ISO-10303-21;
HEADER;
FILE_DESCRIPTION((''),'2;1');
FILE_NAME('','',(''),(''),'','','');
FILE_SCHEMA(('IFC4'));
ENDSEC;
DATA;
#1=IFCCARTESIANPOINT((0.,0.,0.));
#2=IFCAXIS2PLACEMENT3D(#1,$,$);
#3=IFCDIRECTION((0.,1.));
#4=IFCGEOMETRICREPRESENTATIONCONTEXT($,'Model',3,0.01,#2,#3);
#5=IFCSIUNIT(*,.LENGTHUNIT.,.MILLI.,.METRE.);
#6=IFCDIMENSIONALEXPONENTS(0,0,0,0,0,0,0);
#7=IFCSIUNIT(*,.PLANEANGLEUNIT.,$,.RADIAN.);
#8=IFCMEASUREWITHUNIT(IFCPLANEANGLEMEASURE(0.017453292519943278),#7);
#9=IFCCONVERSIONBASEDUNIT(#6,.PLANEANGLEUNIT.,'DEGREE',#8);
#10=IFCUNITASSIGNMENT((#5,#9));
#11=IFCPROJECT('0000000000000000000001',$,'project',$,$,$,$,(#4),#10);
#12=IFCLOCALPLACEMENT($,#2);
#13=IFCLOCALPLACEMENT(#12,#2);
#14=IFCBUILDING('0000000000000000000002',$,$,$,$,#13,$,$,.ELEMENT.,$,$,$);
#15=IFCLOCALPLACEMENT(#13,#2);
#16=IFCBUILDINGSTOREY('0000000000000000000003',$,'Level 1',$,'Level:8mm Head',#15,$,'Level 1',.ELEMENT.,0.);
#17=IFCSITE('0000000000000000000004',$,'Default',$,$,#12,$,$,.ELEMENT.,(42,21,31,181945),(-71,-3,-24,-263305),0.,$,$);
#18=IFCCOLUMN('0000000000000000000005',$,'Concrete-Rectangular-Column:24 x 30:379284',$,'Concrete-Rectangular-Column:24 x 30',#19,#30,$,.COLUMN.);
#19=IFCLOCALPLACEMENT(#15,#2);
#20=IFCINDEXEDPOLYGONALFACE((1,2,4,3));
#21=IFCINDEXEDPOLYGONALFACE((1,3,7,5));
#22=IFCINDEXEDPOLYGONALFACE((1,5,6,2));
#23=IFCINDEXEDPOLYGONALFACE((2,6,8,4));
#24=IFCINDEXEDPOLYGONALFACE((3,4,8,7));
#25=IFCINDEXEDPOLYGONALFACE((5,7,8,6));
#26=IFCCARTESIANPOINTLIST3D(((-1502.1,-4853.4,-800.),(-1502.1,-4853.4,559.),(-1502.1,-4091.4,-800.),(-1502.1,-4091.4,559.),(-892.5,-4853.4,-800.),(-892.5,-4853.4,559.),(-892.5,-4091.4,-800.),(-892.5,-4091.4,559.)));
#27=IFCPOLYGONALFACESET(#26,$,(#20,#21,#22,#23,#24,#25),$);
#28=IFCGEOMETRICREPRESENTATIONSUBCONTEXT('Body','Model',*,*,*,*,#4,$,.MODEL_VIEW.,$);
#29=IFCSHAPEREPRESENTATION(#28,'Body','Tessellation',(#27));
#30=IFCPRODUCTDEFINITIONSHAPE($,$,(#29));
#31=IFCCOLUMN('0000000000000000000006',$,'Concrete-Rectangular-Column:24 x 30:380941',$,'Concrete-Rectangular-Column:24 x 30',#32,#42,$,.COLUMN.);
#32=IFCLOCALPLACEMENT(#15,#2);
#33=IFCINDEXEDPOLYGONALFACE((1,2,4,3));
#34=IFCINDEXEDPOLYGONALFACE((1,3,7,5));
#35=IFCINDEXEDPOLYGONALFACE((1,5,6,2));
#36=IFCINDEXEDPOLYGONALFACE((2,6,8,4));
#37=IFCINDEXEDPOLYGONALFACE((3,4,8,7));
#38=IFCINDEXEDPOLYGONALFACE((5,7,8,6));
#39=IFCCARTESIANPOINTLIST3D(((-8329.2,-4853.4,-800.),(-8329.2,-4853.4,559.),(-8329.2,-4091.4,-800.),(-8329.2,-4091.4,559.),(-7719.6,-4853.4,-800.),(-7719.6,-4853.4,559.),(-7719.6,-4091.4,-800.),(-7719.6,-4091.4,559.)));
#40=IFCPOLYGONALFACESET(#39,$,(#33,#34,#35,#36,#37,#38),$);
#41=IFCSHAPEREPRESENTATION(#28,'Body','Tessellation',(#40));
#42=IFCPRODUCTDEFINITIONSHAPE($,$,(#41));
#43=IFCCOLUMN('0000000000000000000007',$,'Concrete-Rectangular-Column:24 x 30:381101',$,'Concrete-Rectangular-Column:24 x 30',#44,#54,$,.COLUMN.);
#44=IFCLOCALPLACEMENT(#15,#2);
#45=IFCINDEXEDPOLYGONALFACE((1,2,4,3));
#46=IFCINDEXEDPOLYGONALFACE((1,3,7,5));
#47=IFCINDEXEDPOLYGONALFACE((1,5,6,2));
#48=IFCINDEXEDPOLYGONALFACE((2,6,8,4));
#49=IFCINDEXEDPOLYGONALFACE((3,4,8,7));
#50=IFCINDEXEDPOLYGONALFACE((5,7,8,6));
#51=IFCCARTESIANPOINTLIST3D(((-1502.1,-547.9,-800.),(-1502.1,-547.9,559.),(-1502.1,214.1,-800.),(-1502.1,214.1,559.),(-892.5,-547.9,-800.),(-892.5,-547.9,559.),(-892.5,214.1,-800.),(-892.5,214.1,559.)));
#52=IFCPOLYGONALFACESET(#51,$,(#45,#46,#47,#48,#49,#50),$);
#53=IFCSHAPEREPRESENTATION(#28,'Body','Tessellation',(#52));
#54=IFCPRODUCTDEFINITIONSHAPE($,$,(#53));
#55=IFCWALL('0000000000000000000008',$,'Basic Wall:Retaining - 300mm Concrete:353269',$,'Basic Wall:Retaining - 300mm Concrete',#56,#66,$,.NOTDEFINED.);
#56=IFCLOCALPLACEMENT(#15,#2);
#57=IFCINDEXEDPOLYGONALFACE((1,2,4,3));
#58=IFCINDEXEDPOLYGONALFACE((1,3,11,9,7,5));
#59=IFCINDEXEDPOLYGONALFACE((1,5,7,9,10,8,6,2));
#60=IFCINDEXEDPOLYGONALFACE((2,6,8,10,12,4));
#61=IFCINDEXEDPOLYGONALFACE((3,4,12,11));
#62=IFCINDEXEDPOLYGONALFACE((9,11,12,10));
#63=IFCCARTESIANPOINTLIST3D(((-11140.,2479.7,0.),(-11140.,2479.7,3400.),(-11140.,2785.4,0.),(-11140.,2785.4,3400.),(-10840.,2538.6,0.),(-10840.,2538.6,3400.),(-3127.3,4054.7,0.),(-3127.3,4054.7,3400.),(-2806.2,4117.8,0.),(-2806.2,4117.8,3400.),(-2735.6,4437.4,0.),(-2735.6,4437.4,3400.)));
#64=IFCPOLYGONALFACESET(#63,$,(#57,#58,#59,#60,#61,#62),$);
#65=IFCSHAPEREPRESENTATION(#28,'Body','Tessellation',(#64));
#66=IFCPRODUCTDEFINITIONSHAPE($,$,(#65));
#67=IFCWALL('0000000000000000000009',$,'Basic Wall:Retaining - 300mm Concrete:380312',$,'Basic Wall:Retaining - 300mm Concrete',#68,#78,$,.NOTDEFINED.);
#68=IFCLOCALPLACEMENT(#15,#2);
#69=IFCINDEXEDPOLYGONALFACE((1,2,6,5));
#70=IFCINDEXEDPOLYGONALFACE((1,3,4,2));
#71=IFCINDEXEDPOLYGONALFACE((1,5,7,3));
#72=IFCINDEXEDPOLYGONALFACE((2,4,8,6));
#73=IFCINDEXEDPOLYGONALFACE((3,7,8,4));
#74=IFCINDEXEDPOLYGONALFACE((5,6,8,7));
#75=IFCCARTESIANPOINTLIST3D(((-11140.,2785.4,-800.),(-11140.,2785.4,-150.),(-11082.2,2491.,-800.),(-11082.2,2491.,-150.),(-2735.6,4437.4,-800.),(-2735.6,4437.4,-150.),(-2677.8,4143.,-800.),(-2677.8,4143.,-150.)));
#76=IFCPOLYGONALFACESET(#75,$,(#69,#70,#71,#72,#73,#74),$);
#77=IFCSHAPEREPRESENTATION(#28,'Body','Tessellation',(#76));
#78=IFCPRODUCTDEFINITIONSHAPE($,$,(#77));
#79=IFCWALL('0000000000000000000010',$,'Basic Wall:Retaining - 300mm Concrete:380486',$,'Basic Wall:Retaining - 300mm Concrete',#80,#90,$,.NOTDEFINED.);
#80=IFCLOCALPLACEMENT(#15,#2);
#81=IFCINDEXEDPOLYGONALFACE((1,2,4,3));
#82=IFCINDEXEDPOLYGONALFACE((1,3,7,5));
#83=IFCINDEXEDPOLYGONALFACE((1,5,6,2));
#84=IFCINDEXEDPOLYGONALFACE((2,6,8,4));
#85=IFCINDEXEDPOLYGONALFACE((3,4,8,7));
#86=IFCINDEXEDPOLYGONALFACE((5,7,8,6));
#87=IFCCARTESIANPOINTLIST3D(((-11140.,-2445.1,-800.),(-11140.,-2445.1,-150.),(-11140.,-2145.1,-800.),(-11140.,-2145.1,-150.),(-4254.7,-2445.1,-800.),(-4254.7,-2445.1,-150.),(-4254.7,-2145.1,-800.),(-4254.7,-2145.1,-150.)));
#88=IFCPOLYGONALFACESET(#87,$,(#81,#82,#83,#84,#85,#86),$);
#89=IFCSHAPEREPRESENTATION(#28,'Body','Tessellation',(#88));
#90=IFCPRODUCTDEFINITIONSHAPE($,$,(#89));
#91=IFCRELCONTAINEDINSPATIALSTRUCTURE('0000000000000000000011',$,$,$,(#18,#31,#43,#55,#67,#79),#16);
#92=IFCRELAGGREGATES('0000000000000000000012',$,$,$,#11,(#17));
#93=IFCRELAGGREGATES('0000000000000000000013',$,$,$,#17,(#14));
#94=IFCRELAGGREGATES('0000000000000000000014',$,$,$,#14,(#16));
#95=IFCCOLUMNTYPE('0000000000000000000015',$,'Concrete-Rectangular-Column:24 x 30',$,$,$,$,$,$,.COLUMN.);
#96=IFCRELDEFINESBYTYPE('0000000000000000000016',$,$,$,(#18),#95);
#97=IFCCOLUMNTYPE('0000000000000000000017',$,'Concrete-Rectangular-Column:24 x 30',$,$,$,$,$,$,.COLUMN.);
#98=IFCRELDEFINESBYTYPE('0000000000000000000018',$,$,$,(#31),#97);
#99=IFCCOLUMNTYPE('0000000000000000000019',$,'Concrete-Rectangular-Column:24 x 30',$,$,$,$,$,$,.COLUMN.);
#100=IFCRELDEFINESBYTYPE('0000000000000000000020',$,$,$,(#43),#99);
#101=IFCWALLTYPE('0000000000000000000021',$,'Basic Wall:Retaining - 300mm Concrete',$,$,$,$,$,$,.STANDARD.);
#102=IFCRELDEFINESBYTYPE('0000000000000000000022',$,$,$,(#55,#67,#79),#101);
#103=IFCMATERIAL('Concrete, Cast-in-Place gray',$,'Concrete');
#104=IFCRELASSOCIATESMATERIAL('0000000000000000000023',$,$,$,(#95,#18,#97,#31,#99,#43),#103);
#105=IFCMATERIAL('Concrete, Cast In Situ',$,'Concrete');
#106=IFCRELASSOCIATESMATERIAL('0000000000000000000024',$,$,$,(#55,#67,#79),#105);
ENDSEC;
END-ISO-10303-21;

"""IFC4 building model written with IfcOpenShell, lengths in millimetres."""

from ifc_helpers import new_model, entity, si_unit, converted_unit, direction, frame, origin, place, context, subcontext, project, spatial, indexed_curve, outline, extrude, source, transform, mapped, material, type_object, type_shapes, element, save


model = new_model("IFC4")

# Units and contexts
model_context = context("Model", 3, precision=0.01, world=origin(), true_north=direction((0.0, 1.0)))
body_context = subcontext(model_context, "Body", "Model", "MODEL_VIEW")
ifc_project = project(units=[si_unit("LENGTHUNIT", "METRE", prefix="MILLI"), converted_unit("PLANEANGLEUNIT", "DEGREE", entity("IfcPlaneAngleMeasure", 0.017453292519943278), si_unit("PLANEANGLEUNIT", "RADIAN"), dimensions=[0, 0, 0, 0, 0, 0, 0])], contexts=[model_context])

# Site, building, storey
site_placement = place(None, origin())
site = spatial("IfcSite", under=ifc_project, at=site_placement, Name="Default", CompositionType="ELEMENT", RefLatitude=(42, 21, 31, 181945), RefLongitude=(-71, -3, -24, -263305), RefElevation=0.0)
building_placement = place(site_placement, origin())
building = spatial("IfcBuilding", under=site, at=building_placement, CompositionType="ELEMENT")
storey_placement = place(building_placement, origin())
storey = spatial("IfcBuildingStorey", under=building, at=storey_placement, Name="Level 1", ObjectType="Level:8mm Head", LongName="Level 1", CompositionType="ELEMENT", Elevation=0.0)

# Columns
ifc_material_1 = material(Name="Concrete, Cast-in-Place gray", Category="Concrete")
column_type_1 = type_object("IfcColumnType", Name="Concrete-Rectangular-Column:24 x 30", PredefinedType="COLUMN", material=ifc_material_1)
shared_shape_1 = source(origin(), body_context, "Body", "SweptSolid", [
    extrude(outline(indexed_curve([(-679.5, -381.0), (679.5, -381.0), (679.5, 381.0), (-679.5, 381.0), (-679.5, -381.0)], self_intersect=False)), frame((-1502.1, -4472.4, -120.5), z_axis=(1.0, 0.0, 0.0), x_axis=(0.0, 0.0, 1.0)), (0.0, 0.0, 1.0), 609.6),
])
type_shapes(column_type_1, [shared_shape_1])
column_1_placement = place(storey_placement, origin())
element("IfcColumn", 1, at=column_1_placement, inside=storey, type_object=column_type_1, material=ifc_material_1, Name="Concrete-Rectangular-Column:24 x 30:379284", ObjectType="Concrete-Rectangular-Column:24 x 30", PredefinedType="COLUMN", context=body_context, shape_type="MappedRepresentation", body=[
    mapped(shared_shape_1, transform((0.0, 0.0, 0.0), scale=1.0)),
])
column_type_2 = type_object("IfcColumnType", Name="Concrete-Rectangular-Column:24 x 30", PredefinedType="COLUMN", material=ifc_material_1)
shared_shape_2 = source(origin(), body_context, "Body", "SweptSolid", [
    extrude(outline(indexed_curve([(-679.5, -381.0), (679.5, -381.0), (679.5, 381.0), (-679.5, 381.0), (-679.5, -381.0)], self_intersect=False)), frame((-8329.2, -4472.4, -120.5), z_axis=(1.0, 0.0, 0.0), x_axis=(0.0, 0.0, 1.0)), (0.0, 0.0, 1.0), 609.6),
])
type_shapes(column_type_2, [shared_shape_2])
column_2_placement = place(storey_placement, origin())
element("IfcColumn", 2, at=column_2_placement, inside=storey, type_object=column_type_2, material=ifc_material_1, Name="Concrete-Rectangular-Column:24 x 30:380941", ObjectType="Concrete-Rectangular-Column:24 x 30", PredefinedType="COLUMN", context=body_context, shape_type="MappedRepresentation", body=[
    mapped(shared_shape_2, transform((0.0, 0.0, 0.0), scale=1.0)),
])
column_type_3 = type_object("IfcColumnType", Name="Concrete-Rectangular-Column:24 x 30", PredefinedType="COLUMN", material=ifc_material_1)
shared_shape_3 = source(origin(), body_context, "Body", "SweptSolid", [
    extrude(outline(indexed_curve([(-679.5, -381.0), (679.5, -381.0), (679.5, 381.0), (-679.5, 381.0), (-679.5, -381.0)], self_intersect=False)), frame((-1502.1, -166.9, -120.5), z_axis=(1.0, 0.0, 0.0), x_axis=(0.0, 0.0, 1.0)), (0.0, 0.0, 1.0), 609.6),
])
type_shapes(column_type_3, [shared_shape_3])
column_3_placement = place(storey_placement, origin())
element("IfcColumn", 3, at=column_3_placement, inside=storey, type_object=column_type_3, material=ifc_material_1, Name="Concrete-Rectangular-Column:24 x 30:381101", ObjectType="Concrete-Rectangular-Column:24 x 30", PredefinedType="COLUMN", context=body_context, shape_type="MappedRepresentation", body=[
    mapped(shared_shape_3, transform((0.0, 0.0, 0.0), scale=1.0)),
])

# Shared definitions
ifc_material_2 = material(Name="Concrete, Cast In Situ", Category="Concrete")

# Wall
wall_type = type_object("IfcWallType", Name="Basic Wall:Retaining - 300mm Concrete", PredefinedType="STANDARD")
wall_1_placement = place(storey_placement, frame((-11169.0, 2626.8, 0.0), z_axis=(0.0, 0.0, 1.0), x_axis=(0.981224, 0.192871, 0.0)))
element("IfcWall", 4, at=wall_1_placement, inside=storey, type_object=wall_type, material=ifc_material_2, Name="Basic Wall:Retaining - 300mm Concrete:353269", ObjectType="Basic Wall:Retaining - 300mm Concrete", PredefinedType="NOTDEFINED", context=body_context, shape_type="SweptSolid", body=[
    extrude(outline(indexed_curve([(8493.4, -150.0), (8624.2, 150.0), (59.0, 150.0), (0.0, -150.0), (305.7, -150.0), (8166.1, -150.0), (8493.4, -150.0)], self_intersect=False)), origin(), (0.0, 0.0, 1.0), 3400.0),
])

# Walls
wall_2_placement = place(storey_placement, frame((-11111.1, 2638.2, -800.0), z_axis=(0.0, 0.0, 1.0), x_axis=(0.981224, 0.192871, 0.0)))
element("IfcWall", 5, at=wall_2_placement, inside=storey, type_object=wall_type, material=ifc_material_2, Name="Basic Wall:Retaining - 300mm Concrete:380312", ObjectType="Basic Wall:Retaining - 300mm Concrete", PredefinedType="NOTDEFINED", context=body_context, shape_type="SweptSolid", body=[
    extrude(outline(indexed_curve([(8565.2, 150.0), (0.0, 150.0), (0.0, -150.0), (8565.2, -150.0), (8565.2, 150.0)], self_intersect=False)), origin(), (0.0, 0.0, 1.0), 650.0),
])
wall_3_placement = place(storey_placement, frame((-11140.0, -2295.1, -800.0)))
element("IfcWall", 6, at=wall_3_placement, inside=storey, type_object=wall_type, material=ifc_material_2, Name="Basic Wall:Retaining - 300mm Concrete:380486", ObjectType="Basic Wall:Retaining - 300mm Concrete", PredefinedType="NOTDEFINED", context=body_context, shape_type="SweptSolid", body=[
    extrude(outline(indexed_curve([(6885.4, 150.0), (0.0, 150.0), (0.0, -150.0), (6885.4, -150.0), (6885.4, 150.0)], self_intersect=False)), origin(), (0.0, 0.0, 1.0), 650.0),
])

save(model, "model.ifc")
